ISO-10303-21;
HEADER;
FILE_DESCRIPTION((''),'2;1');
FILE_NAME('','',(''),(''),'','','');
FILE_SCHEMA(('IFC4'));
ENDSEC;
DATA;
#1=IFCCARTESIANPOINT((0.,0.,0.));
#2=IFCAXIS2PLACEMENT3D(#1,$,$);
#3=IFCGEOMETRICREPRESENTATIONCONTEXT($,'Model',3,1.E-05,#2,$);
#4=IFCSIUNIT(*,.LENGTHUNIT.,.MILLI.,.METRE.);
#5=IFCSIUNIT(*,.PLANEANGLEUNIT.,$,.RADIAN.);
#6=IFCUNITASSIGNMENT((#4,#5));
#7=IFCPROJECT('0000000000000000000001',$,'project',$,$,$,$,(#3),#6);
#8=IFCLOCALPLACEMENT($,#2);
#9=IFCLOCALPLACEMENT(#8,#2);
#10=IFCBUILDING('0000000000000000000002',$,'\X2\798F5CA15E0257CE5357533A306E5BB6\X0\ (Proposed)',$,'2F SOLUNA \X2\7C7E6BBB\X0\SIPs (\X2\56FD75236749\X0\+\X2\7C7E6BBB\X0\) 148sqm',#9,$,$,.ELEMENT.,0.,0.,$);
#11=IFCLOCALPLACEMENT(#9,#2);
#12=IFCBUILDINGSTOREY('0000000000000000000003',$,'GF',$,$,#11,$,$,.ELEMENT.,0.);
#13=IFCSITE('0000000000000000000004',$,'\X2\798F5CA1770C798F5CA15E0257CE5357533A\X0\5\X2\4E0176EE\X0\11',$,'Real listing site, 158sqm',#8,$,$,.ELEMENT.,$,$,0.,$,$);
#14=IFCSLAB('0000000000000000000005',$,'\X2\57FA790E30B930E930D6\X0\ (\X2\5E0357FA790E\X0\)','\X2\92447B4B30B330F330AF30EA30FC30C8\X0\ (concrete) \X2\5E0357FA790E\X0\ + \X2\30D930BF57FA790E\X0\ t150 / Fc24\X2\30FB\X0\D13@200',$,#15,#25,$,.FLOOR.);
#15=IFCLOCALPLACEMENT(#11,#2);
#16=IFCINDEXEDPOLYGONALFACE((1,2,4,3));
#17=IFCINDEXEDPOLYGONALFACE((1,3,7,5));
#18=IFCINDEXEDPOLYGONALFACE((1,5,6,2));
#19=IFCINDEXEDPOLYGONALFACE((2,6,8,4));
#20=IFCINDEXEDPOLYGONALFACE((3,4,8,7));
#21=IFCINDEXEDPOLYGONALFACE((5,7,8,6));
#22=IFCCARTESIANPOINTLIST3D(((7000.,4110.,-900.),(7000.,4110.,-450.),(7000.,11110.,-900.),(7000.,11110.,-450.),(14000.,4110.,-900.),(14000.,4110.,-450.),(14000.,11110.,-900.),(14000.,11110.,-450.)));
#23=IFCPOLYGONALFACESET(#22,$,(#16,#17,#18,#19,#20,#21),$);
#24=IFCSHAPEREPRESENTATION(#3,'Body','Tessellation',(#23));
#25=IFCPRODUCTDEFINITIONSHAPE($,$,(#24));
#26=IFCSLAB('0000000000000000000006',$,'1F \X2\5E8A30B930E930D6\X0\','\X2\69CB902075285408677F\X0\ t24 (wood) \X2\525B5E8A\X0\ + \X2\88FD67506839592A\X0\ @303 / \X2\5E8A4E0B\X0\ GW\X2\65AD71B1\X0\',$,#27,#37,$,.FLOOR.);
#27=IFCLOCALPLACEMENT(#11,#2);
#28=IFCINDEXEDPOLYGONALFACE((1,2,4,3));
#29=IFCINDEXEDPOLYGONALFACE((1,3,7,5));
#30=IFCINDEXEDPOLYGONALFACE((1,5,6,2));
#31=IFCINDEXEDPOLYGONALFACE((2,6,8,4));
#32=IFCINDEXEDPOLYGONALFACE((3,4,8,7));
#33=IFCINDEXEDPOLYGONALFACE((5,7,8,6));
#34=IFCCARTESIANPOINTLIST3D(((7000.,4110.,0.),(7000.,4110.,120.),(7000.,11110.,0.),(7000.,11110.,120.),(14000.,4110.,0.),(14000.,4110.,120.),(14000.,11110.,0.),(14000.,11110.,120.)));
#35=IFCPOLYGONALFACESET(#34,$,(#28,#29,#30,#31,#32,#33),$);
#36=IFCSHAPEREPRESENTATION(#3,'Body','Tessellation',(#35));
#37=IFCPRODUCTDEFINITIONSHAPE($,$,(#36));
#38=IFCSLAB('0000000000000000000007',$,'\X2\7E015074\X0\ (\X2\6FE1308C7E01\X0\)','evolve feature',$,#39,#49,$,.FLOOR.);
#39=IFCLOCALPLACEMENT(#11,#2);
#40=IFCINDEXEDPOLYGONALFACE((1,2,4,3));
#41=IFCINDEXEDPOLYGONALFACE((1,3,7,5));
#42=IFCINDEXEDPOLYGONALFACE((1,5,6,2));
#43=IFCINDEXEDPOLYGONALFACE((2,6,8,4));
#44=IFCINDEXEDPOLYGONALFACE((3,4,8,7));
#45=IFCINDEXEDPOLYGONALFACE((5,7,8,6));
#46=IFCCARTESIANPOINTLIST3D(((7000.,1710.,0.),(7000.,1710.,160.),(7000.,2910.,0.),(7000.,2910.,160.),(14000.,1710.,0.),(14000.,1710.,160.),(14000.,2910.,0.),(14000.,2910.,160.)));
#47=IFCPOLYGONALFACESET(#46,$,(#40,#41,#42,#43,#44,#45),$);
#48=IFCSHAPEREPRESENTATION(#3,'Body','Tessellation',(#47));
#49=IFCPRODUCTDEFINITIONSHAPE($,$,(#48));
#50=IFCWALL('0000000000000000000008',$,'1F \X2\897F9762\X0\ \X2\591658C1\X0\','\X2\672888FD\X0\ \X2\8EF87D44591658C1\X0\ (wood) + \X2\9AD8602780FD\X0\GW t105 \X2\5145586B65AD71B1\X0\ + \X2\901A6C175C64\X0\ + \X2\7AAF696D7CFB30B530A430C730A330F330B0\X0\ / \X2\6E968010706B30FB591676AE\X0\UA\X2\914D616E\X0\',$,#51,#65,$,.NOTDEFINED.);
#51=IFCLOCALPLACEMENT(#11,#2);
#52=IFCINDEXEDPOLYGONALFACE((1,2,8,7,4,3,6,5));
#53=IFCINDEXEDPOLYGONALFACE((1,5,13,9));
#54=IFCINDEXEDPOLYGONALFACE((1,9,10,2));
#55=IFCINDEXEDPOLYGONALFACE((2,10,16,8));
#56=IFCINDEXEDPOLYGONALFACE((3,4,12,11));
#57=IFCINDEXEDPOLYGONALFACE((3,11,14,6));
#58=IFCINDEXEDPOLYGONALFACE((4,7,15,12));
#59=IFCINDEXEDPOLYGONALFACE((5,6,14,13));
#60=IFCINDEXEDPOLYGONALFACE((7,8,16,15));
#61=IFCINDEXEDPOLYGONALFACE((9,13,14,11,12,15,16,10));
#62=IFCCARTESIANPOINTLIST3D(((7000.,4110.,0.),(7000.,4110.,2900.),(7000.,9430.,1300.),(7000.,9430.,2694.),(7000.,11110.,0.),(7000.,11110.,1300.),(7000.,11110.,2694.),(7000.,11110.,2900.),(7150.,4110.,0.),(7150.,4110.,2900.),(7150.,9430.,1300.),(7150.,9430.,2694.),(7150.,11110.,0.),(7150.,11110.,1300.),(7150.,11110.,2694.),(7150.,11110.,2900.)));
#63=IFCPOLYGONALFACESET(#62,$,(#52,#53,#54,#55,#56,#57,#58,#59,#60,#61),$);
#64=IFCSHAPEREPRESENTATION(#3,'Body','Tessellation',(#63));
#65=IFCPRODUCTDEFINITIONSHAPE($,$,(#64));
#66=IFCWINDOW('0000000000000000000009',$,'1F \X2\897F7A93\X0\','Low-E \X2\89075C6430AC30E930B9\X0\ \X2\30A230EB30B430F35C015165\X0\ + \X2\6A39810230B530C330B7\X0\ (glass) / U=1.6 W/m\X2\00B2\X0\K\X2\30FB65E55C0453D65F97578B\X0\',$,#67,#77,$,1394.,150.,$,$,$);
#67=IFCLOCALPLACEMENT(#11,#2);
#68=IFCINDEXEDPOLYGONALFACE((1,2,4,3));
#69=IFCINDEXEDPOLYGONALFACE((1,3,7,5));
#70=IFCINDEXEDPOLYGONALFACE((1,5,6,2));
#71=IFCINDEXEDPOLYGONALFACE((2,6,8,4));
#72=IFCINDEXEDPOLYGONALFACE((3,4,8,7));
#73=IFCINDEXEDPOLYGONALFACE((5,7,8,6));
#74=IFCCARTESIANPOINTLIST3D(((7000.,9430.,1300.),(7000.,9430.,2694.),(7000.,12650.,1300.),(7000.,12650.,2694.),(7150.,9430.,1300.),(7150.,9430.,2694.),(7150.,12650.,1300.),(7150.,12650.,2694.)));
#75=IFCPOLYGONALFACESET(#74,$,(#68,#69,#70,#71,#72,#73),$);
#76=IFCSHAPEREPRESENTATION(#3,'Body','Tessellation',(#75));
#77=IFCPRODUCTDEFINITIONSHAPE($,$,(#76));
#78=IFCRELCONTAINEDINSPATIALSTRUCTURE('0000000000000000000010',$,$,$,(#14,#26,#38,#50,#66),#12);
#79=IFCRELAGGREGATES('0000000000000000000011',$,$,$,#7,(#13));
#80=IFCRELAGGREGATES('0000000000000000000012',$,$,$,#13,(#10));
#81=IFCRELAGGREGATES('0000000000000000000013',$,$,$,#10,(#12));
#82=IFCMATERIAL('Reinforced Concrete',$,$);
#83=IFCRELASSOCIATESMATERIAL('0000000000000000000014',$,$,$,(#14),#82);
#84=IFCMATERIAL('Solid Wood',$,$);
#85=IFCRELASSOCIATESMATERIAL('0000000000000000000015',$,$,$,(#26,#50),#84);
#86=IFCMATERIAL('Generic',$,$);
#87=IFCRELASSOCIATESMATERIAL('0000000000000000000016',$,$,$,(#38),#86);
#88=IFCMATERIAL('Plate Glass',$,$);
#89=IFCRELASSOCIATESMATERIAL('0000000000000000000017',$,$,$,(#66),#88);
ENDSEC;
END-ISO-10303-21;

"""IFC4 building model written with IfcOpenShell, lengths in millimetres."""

from ifc_helpers import new_model, si_unit, frame, frame_2d, origin, place, context, project, spatial, rectangle, extrude, material, element, fill, save


model = new_model("IFC4")

# Units and contexts
model_context = context("Model", 3, precision=1e-05, world=origin())
ifc_project = project(units=[si_unit("LENGTHUNIT", "METRE", prefix="MILLI"), si_unit("PLANEANGLEUNIT", "RADIAN")], contexts=[model_context])

# Site, building, storey
site_placement = place(None, origin())
site = spatial("IfcSite", under=ifc_project, at=site_placement, Name="福岡県福岡市城南区5丁目11", ObjectType="Real listing site, 158sqm", CompositionType="ELEMENT", RefElevation=0.0)
building_placement = place(site_placement, origin())
building = spatial("IfcBuilding", under=site, at=building_placement, Name="福岡市城南区の家 (Proposed)", ObjectType="2F SOLUNA 籾殻SIPs (国産杉+籾殻) 148sqm", CompositionType="ELEMENT", ElevationOfRefHeight=0.0, ElevationOfTerrain=0.0)
storey_placement = place(building_placement, origin())
storey = spatial("IfcBuildingStorey", under=building, at=storey_placement, Name="GF", CompositionType="ELEMENT", Elevation=0.0)

# Slabs
ifc_material_1 = material(Name="Reinforced Concrete")
slab_1_placement = place(storey_placement, frame((3500.0, 2055.0, -450.0)))
element("IfcSlab", 1, at=slab_1_placement, inside=storey, material=ifc_material_1, Name="基礎スラブ (布基礎)", Description="鉄筋コンクリート (concrete) 布基礎 + ベタ基礎 t150 / Fc24・D13@200", PredefinedType="FLOOR", context=model_context, shape_type="SweptSolid", body=[
    extrude(rectangle(XDim=7000.0, YDim=7000.0, at=frame_2d((3500.0, 3500.0))), frame((3500.0, 2055.0, -450.0)), (0.0, 0.0, 1.0), 450.0),
])
ifc_material_2 = material(Name="Solid Wood")
slab_2_placement = place(storey_placement, frame((3500.0, 2055.0, 0.0)))
element("IfcSlab", 2, at=slab_2_placement, inside=storey, material=ifc_material_2, Name="1F 床スラブ", Description="構造用合板 t24 (wood) 剛床 + 製材根太 @303 / 床下 GW断熱", PredefinedType="FLOOR", context=model_context, shape_type="SweptSolid", body=[
    extrude(rectangle(XDim=7000.0, YDim=7000.0, at=frame_2d((3500.0, 3500.0))), frame((3500.0, 2055.0, 0.0)), (0.0, 0.0, 1.0), 120.0),
])
ifc_material_3 = material(Name="Generic")
slab_3_placement = place(storey_placement, frame((3500.0, 855.0, 0.0)))
element("IfcSlab", 3, at=slab_3_placement, inside=storey, material=ifc_material_3, Name="縁側 (濡れ縁)", Description="evolve feature", PredefinedType="FLOOR", context=model_context, shape_type="SweptSolid", body=[
    extrude(rectangle(XDim=7000.0, YDim=1200.0, at=frame_2d((3500.0, 600.0))), frame((3500.0, 855.0, 0.0)), (0.0, 0.0, 1.0), 160.0),
])

# Shared definitions
ifc_material_4 = material(Name="Plate Glass")

# Wall, opening, window
wall_1_placement = place(storey_placement, frame((3500.0, 2055.0, 0.0)))
wall_1 = element("IfcWall", 4, at=wall_1_placement, inside=storey, material=ifc_material_2, Name="1F 西面 外壁", Description="木製 軸組外壁 (wood) + 高性能GW t105 充填断熱 + 通気層 + 窯業系サイディング / 準耐火・外皮UA配慮", PredefinedType="NOTDEFINED", context=model_context, shape_type="SweptSolid", body=[
    extrude(rectangle(XDim=150.0, YDim=7000.0, at=frame_2d((75.0, 3500.0))), frame((3500.0, 2055.0, 0.0)), (0.0, 0.0, 1.0), 2900.0),
])
opening_1_placement = place(storey_placement, frame((3500.0, 4715.0, 650.0)))
opening_1 = element("IfcOpeningElement", 5, at=opening_1_placement, cuts=wall_1, PredefinedType="NOTDEFINED", context=model_context, shape_type="SweptSolid", body=[
    extrude(rectangle(XDim=150.0, YDim=3220.0, at=frame_2d((75.0, 1610.0))), frame((3500.0, 4715.0, 650.0)), (0.0, 0.0, 1.0), 1394.0),
])
window_1_placement = place(storey_placement, frame((3500.0, 4715.0, 650.0)))
window_1 = element("IfcWindow", 6, at=window_1_placement, inside=storey, material=ifc_material_4, Name="1F 西窓", Description="Low-E 複層ガラス アルゴン封入 + 樹脂サッシ (glass) / U=1.6 W/m²K・日射取得型", OverallHeight=1394.0, OverallWidth=150.0, context=model_context, shape_type="SweptSolid", body=[
    extrude(rectangle(XDim=150.0, YDim=3220.0, at=frame_2d((75.0, 1610.0))), frame((3500.0, 4715.0, 650.0)), (0.0, 0.0, 1.0), 1394.0),
])
fill(opening_1, window_1)

save(model, "model.ifc")
